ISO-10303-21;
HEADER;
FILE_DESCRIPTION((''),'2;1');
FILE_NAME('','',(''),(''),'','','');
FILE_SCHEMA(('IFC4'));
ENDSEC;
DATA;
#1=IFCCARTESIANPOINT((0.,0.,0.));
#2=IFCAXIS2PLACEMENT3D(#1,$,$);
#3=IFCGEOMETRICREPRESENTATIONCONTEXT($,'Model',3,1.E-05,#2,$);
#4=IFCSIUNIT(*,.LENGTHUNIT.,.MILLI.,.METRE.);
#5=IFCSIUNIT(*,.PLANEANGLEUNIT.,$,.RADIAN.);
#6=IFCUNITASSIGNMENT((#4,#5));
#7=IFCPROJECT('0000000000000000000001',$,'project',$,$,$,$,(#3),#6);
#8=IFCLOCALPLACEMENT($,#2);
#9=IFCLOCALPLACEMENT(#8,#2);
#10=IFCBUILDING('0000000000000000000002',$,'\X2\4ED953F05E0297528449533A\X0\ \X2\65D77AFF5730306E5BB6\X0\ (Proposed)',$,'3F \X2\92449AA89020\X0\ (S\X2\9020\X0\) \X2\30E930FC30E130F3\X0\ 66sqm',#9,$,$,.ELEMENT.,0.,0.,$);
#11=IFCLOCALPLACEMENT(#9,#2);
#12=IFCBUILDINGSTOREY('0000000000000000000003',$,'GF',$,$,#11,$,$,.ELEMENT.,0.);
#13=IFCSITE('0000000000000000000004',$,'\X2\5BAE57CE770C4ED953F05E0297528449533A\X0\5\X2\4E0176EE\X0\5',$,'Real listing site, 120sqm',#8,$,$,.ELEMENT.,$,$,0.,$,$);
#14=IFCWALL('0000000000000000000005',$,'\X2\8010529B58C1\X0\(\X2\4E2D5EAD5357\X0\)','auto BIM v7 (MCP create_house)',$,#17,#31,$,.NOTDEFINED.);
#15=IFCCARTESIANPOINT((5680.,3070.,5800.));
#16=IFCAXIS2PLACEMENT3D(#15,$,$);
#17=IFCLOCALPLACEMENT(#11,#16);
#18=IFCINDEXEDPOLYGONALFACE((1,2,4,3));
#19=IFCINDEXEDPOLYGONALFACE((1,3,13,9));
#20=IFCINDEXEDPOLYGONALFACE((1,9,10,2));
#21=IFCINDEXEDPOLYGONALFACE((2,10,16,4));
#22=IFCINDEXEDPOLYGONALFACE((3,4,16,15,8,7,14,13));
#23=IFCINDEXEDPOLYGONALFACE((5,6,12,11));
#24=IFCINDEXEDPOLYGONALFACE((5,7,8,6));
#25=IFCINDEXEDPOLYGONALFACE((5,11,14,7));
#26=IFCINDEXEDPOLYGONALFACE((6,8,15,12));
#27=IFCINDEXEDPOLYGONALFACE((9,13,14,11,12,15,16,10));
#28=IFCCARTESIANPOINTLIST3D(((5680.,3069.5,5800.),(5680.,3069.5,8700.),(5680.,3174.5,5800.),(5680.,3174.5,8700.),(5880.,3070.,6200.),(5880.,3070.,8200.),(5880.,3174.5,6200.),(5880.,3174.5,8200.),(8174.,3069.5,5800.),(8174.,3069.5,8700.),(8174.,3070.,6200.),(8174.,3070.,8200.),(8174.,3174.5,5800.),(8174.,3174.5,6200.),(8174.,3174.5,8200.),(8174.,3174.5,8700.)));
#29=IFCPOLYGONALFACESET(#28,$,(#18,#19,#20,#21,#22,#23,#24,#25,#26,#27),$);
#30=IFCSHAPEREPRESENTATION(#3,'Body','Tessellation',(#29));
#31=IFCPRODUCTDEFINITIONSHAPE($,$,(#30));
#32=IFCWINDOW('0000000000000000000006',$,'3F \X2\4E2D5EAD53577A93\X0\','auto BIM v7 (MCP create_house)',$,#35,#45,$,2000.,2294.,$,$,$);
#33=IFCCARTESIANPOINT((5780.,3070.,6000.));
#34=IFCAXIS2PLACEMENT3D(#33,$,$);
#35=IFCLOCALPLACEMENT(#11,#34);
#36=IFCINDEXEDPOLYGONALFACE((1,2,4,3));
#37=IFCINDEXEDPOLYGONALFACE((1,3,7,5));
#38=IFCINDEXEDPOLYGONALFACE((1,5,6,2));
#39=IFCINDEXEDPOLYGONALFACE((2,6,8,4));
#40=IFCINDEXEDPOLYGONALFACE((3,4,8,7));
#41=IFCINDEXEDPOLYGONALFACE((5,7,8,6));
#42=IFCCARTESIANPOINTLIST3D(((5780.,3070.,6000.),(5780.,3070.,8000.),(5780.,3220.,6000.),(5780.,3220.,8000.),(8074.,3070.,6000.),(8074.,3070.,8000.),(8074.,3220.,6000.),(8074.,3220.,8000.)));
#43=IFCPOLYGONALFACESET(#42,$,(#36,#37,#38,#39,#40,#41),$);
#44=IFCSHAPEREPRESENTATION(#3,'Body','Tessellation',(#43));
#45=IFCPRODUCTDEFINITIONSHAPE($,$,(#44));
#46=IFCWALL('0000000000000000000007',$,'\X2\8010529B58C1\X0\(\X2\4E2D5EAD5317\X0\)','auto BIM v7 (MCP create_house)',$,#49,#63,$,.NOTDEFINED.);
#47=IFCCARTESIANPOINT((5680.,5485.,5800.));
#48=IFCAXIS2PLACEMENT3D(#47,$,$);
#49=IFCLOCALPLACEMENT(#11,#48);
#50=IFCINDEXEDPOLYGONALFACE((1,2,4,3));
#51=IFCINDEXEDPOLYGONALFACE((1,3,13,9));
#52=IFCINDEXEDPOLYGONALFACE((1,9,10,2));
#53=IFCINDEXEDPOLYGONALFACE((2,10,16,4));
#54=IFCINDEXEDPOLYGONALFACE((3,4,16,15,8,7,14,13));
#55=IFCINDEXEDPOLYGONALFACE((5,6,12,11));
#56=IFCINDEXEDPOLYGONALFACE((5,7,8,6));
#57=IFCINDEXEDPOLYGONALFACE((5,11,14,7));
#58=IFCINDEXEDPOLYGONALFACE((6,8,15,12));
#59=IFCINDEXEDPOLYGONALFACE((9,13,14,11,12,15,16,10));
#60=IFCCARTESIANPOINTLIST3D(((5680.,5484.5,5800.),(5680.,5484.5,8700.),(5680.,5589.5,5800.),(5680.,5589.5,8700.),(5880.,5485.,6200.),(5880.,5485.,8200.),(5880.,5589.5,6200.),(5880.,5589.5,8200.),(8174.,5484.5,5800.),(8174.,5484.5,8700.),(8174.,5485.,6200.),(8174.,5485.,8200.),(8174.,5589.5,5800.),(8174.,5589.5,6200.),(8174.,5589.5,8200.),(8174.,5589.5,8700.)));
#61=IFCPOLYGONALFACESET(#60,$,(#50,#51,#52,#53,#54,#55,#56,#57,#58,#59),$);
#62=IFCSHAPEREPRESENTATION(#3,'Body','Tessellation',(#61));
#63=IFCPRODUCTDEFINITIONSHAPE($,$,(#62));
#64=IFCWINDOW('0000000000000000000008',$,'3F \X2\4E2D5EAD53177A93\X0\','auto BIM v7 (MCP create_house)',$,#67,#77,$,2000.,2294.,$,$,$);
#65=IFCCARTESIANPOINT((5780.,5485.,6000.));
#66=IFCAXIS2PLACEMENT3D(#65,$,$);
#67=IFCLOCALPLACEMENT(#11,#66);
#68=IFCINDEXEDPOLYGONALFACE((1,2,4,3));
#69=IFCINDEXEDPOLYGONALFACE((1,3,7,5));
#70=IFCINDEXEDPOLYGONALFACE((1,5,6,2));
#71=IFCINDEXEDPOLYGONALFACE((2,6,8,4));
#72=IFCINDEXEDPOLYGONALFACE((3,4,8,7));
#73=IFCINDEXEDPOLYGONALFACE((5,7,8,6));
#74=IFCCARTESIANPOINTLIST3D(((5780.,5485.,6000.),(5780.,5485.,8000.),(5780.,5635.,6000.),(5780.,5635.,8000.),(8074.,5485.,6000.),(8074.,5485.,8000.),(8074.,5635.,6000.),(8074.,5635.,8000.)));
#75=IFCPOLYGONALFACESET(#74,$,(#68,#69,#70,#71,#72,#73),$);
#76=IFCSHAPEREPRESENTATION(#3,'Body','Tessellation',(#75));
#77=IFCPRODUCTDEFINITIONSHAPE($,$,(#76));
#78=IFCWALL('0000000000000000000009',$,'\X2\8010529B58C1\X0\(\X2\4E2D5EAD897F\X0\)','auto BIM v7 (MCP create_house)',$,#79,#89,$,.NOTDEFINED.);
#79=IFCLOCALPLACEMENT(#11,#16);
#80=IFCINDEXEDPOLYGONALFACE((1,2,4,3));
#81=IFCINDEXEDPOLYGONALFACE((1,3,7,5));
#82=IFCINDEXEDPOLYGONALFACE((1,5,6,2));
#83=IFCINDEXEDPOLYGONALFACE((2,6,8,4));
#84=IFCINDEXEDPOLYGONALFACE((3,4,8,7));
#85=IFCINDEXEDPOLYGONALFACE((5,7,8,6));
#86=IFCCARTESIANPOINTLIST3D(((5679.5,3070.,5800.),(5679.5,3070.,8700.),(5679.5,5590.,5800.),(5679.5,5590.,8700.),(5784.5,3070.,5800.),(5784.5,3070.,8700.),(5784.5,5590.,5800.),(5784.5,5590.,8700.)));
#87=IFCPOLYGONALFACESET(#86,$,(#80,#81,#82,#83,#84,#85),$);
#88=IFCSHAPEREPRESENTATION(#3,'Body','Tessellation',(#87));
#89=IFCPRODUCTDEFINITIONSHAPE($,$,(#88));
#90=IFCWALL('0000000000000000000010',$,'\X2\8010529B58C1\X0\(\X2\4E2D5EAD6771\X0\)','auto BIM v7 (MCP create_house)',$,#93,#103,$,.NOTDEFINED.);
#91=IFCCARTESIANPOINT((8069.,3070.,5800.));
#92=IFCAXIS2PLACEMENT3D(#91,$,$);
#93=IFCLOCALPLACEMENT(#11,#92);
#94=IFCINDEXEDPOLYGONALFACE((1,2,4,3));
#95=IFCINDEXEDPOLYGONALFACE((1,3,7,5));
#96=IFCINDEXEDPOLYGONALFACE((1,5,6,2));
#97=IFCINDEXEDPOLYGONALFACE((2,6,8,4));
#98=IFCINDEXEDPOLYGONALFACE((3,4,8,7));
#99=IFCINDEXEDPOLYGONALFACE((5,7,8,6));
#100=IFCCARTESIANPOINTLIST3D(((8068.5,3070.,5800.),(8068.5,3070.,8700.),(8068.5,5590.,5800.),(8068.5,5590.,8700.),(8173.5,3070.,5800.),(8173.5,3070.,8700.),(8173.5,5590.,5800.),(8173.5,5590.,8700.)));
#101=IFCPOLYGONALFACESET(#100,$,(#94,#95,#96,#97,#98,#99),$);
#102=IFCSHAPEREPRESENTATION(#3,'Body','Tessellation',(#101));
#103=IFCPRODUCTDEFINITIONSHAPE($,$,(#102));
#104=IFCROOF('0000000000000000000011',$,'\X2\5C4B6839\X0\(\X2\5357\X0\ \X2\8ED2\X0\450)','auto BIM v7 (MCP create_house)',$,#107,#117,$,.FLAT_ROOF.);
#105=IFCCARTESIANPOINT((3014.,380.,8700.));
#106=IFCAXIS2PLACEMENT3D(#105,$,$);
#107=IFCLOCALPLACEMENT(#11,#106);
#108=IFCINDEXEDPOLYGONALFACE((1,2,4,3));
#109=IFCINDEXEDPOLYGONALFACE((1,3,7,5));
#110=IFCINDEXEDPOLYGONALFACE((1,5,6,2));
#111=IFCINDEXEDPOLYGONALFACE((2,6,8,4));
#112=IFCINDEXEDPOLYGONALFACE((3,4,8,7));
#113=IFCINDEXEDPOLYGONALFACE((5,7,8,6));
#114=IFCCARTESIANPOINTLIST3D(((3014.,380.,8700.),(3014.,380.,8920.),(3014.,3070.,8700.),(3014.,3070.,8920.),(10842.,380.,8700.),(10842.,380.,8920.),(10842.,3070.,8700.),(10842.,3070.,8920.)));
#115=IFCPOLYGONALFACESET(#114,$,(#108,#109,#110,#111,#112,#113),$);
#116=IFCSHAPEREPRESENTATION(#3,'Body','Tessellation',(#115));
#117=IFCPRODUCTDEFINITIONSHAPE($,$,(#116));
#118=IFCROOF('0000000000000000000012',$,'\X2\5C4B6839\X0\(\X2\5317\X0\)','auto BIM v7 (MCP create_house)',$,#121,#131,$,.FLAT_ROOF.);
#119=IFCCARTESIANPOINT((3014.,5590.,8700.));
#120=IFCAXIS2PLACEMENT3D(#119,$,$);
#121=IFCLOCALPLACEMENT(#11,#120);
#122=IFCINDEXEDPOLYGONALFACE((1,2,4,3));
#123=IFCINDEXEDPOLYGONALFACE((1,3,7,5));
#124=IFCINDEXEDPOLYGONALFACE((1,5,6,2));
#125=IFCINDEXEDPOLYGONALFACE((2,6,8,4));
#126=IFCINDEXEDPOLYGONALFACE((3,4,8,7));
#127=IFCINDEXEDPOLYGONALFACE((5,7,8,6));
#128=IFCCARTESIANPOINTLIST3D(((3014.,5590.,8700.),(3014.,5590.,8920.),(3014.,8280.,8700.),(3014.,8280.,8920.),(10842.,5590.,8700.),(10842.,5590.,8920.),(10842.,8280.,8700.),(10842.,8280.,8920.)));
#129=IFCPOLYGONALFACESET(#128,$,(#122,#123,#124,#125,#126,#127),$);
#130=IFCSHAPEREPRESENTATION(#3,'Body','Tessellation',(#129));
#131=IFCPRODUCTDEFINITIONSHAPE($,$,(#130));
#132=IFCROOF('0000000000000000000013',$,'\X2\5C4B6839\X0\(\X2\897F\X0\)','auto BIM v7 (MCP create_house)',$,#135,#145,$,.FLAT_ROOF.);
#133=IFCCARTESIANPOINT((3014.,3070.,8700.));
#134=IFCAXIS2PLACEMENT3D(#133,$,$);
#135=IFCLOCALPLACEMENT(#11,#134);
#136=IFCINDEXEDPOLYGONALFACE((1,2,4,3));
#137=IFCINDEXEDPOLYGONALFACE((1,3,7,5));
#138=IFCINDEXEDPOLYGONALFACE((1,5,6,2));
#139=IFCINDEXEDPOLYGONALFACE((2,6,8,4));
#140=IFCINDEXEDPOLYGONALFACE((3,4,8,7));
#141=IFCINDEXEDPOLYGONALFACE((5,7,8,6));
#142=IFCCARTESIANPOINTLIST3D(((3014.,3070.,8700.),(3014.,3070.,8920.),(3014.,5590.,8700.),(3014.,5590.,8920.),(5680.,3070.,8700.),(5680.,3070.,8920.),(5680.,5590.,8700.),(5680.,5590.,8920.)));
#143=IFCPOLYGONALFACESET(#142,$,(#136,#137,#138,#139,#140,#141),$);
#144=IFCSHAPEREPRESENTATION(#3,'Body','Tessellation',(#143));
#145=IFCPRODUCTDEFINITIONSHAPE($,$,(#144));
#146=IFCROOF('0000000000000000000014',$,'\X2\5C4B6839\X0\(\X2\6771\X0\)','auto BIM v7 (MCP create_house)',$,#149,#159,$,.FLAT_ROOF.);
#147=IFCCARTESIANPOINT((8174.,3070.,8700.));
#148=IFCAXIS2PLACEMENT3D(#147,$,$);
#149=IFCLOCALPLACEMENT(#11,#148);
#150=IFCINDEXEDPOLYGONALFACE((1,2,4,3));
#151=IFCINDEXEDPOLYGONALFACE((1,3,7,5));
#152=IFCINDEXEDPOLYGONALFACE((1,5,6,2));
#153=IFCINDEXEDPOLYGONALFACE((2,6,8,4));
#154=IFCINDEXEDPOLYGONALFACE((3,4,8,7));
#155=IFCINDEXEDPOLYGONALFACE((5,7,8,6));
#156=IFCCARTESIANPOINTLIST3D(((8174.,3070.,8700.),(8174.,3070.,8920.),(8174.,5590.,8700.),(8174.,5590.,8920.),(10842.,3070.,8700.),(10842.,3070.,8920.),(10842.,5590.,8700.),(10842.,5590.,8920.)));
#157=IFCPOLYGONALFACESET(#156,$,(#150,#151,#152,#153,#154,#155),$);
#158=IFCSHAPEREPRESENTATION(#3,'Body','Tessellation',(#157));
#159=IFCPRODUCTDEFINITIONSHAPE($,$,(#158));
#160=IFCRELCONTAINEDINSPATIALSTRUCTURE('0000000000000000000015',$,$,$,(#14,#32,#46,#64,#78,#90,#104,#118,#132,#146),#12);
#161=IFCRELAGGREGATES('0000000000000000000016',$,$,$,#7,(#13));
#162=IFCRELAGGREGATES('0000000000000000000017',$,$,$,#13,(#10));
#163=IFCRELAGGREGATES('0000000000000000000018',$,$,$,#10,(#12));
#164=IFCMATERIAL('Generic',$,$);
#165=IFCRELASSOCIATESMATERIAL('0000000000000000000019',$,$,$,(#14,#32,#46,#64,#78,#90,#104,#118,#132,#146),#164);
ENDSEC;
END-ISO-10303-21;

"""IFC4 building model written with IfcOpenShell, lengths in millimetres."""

from ifc_helpers import new_model, si_unit, frame, frame_2d, origin, place, context, project, spatial, rectangle, extrude, material, element, fill, save


model = new_model("IFC4")

# Units and contexts
model_context = context("Model", 3, precision=1e-05, world=origin())
ifc_project = project(units=[si_unit("LENGTHUNIT", "METRE", prefix="MILLI"), si_unit("PLANEANGLEUNIT", "RADIAN")], contexts=[model_context])

# Site, building, storey
site_placement = place(None, origin())
site = spatial("IfcSite", under=ifc_project, at=site_placement, Name="宮城県仙台市青葉区5丁目5", ObjectType="Real listing site, 120sqm", CompositionType="ELEMENT", RefElevation=0.0)
building_placement = place(site_placement, origin())
building = spatial("IfcBuilding", under=site, at=building_placement, Name="仙台市青葉区 旗竿地の家 (Proposed)", ObjectType="3F 鉄骨造 (S造) ラーメン 66sqm", CompositionType="ELEMENT", ElevationOfRefHeight=0.0, ElevationOfTerrain=0.0)
storey_placement = place(building_placement, origin())
storey = spatial("IfcBuildingStorey", under=building, at=storey_placement, Name="GF", CompositionType="ELEMENT", Elevation=0.0)

# Shared definitions
ifc_material = material(Name="Generic")

# Walls, openings, windows
wall_1_placement = place(storey_placement, frame((5680.0, 3070.0, 5800.0)))
wall_1 = element("IfcWall", 1, at=wall_1_placement, inside=storey, material=ifc_material, Name="耐力壁(中庭南)", Description="auto BIM v7 (MCP create_house)", PredefinedType="NOTDEFINED", context=model_context, shape_type="SweptSolid", body=[
    extrude(rectangle(XDim=2494.0, YDim=105.0, at=frame_2d((1247.0, 52.0))), frame((5680.0, 3070.0, 5800.0)), (0.0, 0.0, 1.0), 2900.0),
])
opening_1_placement = place(storey_placement, frame((5780.0, 3070.0, 6000.0)))
opening_1 = element("IfcOpeningElement", 2, at=opening_1_placement, cuts=wall_1, PredefinedType="NOTDEFINED", context=model_context, shape_type="SweptSolid", body=[
    extrude(rectangle(XDim=2294.0, YDim=150.0, at=frame_2d((1147.0, 75.0))), frame((5780.0, 3070.0, 6000.0)), (0.0, 0.0, 1.0), 2000.0),
])
window_1_placement = place(storey_placement, frame((5780.0, 3070.0, 6000.0)))
window_1 = element("IfcWindow", 3, at=window_1_placement, inside=storey, material=ifc_material, Name="3F 中庭南窓", Description="auto BIM v7 (MCP create_house)", OverallHeight=2000.0, OverallWidth=2294.0, context=model_context, shape_type="SweptSolid", body=[
    extrude(rectangle(XDim=2294.0, YDim=150.0, at=frame_2d((1147.0, 75.0))), frame((5780.0, 3070.0, 6000.0)), (0.0, 0.0, 1.0), 2000.0),
])
fill(opening_1, window_1)
wall_2_placement = place(storey_placement, frame((5680.0, 5485.0, 5800.0)))
wall_2 = element("IfcWall", 4, at=wall_2_placement, inside=storey, material=ifc_material, Name="耐力壁(中庭北)", Description="auto BIM v7 (MCP create_house)", PredefinedType="NOTDEFINED", context=model_context, shape_type="SweptSolid", body=[
    extrude(rectangle(XDim=2494.0, YDim=105.0, at=frame_2d((1247.0, 52.0))), frame((5680.0, 5485.0, 5800.0)), (0.0, 0.0, 1.0), 2900.0),
])
opening_2_placement = place(storey_placement, frame((5780.0, 5485.0, 6000.0)))
opening_2 = element("IfcOpeningElement", 5, at=opening_2_placement, cuts=wall_2, PredefinedType="NOTDEFINED", context=model_context, shape_type="SweptSolid", body=[
    extrude(rectangle(XDim=2294.0, YDim=150.0, at=frame_2d((1147.0, 75.0))), frame((5780.0, 5485.0, 6000.0)), (0.0, 0.0, 1.0), 2000.0),
])
window_2_placement = place(storey_placement, frame((5780.0, 5485.0, 6000.0)))
window_2 = element("IfcWindow", 6, at=window_2_placement, inside=storey, material=ifc_material, Name="3F 中庭北窓", Description="auto BIM v7 (MCP create_house)", OverallHeight=2000.0, OverallWidth=2294.0, context=model_context, shape_type="SweptSolid", body=[
    extrude(rectangle(XDim=2294.0, YDim=150.0, at=frame_2d((1147.0, 75.0))), frame((5780.0, 5485.0, 6000.0)), (0.0, 0.0, 1.0), 2000.0),
])
fill(opening_2, window_2)

# Walls
wall_3_placement = place(storey_placement, frame((5680.0, 3070.0, 5800.0)))
element("IfcWall", 7, at=wall_3_placement, inside=storey, material=ifc_material, Name="耐力壁(中庭西)", Description="auto BIM v7 (MCP create_house)", PredefinedType="NOTDEFINED", context=model_context, shape_type="SweptSolid", body=[
    extrude(rectangle(XDim=105.0, YDim=2520.0, at=frame_2d((52.0, 1260.0))), frame((5680.0, 3070.0, 5800.0)), (0.0, 0.0, 1.0), 2900.0),
])
wall_4_placement = place(storey_placement, frame((8069.0, 3070.0, 5800.0)))
element("IfcWall", 8, at=wall_4_placement, inside=storey, material=ifc_material, Name="耐力壁(中庭東)", Description="auto BIM v7 (MCP create_house)", PredefinedType="NOTDEFINED", context=model_context, shape_type="SweptSolid", body=[
    extrude(rectangle(XDim=105.0, YDim=2520.0, at=frame_2d((52.0, 1260.0))), frame((8069.0, 3070.0, 5800.0)), (0.0, 0.0, 1.0), 2900.0),
])

# Roofs
roof_1_placement = place(storey_placement, frame((3014.0, 380.0, 8700.0)))
element("IfcRoof", 9, at=roof_1_placement, inside=storey, material=ifc_material, Name="屋根(南 軒450)", Description="auto BIM v7 (MCP create_house)", PredefinedType="FLAT_ROOF", context=model_context, shape_type="SweptSolid", body=[
    extrude(rectangle(XDim=7828.0, YDim=2690.0, at=frame_2d((3914.0, 1345.0))), frame((3014.0, 380.0, 8700.0)), (0.0, 0.0, 1.0), 220.0),
])
roof_2_placement = place(storey_placement, frame((3014.0, 5590.0, 8700.0)))
element("IfcRoof", 10, at=roof_2_placement, inside=storey, material=ifc_material, Name="屋根(北)", Description="auto BIM v7 (MCP create_house)", PredefinedType="FLAT_ROOF", context=model_context, shape_type="SweptSolid", body=[
    extrude(rectangle(XDim=7828.0, YDim=2690.0, at=frame_2d((3914.0, 1345.0))), frame((3014.0, 5590.0, 8700.0)), (0.0, 0.0, 1.0), 220.0),
])
roof_3_placement = place(storey_placement, frame((3014.0, 3070.0, 8700.0)))
element("IfcRoof", 11, at=roof_3_placement, inside=storey, material=ifc_material, Name="屋根(西)", Description="auto BIM v7 (MCP create_house)", PredefinedType="FLAT_ROOF", context=model_context, shape_type="SweptSolid", body=[
    extrude(rectangle(XDim=2666.0, YDim=2520.0, at=frame_2d((1333.0, 1260.0))), frame((3014.0, 3070.0, 8700.0)), (0.0, 0.0, 1.0), 220.0),
])
roof_4_placement = place(storey_placement, frame((8174.0, 3070.0, 8700.0)))
element("IfcRoof", 12, at=roof_4_placement, inside=storey, material=ifc_material, Name="屋根(東)", Description="auto BIM v7 (MCP create_house)", PredefinedType="FLAT_ROOF", context=model_context, shape_type="SweptSolid", body=[
    extrude(rectangle(XDim=2668.0, YDim=2520.0, at=frame_2d((1334.0, 1260.0))), frame((8174.0, 3070.0, 8700.0)), (0.0, 0.0, 1.0), 220.0),
])

save(model, "model.ifc")
